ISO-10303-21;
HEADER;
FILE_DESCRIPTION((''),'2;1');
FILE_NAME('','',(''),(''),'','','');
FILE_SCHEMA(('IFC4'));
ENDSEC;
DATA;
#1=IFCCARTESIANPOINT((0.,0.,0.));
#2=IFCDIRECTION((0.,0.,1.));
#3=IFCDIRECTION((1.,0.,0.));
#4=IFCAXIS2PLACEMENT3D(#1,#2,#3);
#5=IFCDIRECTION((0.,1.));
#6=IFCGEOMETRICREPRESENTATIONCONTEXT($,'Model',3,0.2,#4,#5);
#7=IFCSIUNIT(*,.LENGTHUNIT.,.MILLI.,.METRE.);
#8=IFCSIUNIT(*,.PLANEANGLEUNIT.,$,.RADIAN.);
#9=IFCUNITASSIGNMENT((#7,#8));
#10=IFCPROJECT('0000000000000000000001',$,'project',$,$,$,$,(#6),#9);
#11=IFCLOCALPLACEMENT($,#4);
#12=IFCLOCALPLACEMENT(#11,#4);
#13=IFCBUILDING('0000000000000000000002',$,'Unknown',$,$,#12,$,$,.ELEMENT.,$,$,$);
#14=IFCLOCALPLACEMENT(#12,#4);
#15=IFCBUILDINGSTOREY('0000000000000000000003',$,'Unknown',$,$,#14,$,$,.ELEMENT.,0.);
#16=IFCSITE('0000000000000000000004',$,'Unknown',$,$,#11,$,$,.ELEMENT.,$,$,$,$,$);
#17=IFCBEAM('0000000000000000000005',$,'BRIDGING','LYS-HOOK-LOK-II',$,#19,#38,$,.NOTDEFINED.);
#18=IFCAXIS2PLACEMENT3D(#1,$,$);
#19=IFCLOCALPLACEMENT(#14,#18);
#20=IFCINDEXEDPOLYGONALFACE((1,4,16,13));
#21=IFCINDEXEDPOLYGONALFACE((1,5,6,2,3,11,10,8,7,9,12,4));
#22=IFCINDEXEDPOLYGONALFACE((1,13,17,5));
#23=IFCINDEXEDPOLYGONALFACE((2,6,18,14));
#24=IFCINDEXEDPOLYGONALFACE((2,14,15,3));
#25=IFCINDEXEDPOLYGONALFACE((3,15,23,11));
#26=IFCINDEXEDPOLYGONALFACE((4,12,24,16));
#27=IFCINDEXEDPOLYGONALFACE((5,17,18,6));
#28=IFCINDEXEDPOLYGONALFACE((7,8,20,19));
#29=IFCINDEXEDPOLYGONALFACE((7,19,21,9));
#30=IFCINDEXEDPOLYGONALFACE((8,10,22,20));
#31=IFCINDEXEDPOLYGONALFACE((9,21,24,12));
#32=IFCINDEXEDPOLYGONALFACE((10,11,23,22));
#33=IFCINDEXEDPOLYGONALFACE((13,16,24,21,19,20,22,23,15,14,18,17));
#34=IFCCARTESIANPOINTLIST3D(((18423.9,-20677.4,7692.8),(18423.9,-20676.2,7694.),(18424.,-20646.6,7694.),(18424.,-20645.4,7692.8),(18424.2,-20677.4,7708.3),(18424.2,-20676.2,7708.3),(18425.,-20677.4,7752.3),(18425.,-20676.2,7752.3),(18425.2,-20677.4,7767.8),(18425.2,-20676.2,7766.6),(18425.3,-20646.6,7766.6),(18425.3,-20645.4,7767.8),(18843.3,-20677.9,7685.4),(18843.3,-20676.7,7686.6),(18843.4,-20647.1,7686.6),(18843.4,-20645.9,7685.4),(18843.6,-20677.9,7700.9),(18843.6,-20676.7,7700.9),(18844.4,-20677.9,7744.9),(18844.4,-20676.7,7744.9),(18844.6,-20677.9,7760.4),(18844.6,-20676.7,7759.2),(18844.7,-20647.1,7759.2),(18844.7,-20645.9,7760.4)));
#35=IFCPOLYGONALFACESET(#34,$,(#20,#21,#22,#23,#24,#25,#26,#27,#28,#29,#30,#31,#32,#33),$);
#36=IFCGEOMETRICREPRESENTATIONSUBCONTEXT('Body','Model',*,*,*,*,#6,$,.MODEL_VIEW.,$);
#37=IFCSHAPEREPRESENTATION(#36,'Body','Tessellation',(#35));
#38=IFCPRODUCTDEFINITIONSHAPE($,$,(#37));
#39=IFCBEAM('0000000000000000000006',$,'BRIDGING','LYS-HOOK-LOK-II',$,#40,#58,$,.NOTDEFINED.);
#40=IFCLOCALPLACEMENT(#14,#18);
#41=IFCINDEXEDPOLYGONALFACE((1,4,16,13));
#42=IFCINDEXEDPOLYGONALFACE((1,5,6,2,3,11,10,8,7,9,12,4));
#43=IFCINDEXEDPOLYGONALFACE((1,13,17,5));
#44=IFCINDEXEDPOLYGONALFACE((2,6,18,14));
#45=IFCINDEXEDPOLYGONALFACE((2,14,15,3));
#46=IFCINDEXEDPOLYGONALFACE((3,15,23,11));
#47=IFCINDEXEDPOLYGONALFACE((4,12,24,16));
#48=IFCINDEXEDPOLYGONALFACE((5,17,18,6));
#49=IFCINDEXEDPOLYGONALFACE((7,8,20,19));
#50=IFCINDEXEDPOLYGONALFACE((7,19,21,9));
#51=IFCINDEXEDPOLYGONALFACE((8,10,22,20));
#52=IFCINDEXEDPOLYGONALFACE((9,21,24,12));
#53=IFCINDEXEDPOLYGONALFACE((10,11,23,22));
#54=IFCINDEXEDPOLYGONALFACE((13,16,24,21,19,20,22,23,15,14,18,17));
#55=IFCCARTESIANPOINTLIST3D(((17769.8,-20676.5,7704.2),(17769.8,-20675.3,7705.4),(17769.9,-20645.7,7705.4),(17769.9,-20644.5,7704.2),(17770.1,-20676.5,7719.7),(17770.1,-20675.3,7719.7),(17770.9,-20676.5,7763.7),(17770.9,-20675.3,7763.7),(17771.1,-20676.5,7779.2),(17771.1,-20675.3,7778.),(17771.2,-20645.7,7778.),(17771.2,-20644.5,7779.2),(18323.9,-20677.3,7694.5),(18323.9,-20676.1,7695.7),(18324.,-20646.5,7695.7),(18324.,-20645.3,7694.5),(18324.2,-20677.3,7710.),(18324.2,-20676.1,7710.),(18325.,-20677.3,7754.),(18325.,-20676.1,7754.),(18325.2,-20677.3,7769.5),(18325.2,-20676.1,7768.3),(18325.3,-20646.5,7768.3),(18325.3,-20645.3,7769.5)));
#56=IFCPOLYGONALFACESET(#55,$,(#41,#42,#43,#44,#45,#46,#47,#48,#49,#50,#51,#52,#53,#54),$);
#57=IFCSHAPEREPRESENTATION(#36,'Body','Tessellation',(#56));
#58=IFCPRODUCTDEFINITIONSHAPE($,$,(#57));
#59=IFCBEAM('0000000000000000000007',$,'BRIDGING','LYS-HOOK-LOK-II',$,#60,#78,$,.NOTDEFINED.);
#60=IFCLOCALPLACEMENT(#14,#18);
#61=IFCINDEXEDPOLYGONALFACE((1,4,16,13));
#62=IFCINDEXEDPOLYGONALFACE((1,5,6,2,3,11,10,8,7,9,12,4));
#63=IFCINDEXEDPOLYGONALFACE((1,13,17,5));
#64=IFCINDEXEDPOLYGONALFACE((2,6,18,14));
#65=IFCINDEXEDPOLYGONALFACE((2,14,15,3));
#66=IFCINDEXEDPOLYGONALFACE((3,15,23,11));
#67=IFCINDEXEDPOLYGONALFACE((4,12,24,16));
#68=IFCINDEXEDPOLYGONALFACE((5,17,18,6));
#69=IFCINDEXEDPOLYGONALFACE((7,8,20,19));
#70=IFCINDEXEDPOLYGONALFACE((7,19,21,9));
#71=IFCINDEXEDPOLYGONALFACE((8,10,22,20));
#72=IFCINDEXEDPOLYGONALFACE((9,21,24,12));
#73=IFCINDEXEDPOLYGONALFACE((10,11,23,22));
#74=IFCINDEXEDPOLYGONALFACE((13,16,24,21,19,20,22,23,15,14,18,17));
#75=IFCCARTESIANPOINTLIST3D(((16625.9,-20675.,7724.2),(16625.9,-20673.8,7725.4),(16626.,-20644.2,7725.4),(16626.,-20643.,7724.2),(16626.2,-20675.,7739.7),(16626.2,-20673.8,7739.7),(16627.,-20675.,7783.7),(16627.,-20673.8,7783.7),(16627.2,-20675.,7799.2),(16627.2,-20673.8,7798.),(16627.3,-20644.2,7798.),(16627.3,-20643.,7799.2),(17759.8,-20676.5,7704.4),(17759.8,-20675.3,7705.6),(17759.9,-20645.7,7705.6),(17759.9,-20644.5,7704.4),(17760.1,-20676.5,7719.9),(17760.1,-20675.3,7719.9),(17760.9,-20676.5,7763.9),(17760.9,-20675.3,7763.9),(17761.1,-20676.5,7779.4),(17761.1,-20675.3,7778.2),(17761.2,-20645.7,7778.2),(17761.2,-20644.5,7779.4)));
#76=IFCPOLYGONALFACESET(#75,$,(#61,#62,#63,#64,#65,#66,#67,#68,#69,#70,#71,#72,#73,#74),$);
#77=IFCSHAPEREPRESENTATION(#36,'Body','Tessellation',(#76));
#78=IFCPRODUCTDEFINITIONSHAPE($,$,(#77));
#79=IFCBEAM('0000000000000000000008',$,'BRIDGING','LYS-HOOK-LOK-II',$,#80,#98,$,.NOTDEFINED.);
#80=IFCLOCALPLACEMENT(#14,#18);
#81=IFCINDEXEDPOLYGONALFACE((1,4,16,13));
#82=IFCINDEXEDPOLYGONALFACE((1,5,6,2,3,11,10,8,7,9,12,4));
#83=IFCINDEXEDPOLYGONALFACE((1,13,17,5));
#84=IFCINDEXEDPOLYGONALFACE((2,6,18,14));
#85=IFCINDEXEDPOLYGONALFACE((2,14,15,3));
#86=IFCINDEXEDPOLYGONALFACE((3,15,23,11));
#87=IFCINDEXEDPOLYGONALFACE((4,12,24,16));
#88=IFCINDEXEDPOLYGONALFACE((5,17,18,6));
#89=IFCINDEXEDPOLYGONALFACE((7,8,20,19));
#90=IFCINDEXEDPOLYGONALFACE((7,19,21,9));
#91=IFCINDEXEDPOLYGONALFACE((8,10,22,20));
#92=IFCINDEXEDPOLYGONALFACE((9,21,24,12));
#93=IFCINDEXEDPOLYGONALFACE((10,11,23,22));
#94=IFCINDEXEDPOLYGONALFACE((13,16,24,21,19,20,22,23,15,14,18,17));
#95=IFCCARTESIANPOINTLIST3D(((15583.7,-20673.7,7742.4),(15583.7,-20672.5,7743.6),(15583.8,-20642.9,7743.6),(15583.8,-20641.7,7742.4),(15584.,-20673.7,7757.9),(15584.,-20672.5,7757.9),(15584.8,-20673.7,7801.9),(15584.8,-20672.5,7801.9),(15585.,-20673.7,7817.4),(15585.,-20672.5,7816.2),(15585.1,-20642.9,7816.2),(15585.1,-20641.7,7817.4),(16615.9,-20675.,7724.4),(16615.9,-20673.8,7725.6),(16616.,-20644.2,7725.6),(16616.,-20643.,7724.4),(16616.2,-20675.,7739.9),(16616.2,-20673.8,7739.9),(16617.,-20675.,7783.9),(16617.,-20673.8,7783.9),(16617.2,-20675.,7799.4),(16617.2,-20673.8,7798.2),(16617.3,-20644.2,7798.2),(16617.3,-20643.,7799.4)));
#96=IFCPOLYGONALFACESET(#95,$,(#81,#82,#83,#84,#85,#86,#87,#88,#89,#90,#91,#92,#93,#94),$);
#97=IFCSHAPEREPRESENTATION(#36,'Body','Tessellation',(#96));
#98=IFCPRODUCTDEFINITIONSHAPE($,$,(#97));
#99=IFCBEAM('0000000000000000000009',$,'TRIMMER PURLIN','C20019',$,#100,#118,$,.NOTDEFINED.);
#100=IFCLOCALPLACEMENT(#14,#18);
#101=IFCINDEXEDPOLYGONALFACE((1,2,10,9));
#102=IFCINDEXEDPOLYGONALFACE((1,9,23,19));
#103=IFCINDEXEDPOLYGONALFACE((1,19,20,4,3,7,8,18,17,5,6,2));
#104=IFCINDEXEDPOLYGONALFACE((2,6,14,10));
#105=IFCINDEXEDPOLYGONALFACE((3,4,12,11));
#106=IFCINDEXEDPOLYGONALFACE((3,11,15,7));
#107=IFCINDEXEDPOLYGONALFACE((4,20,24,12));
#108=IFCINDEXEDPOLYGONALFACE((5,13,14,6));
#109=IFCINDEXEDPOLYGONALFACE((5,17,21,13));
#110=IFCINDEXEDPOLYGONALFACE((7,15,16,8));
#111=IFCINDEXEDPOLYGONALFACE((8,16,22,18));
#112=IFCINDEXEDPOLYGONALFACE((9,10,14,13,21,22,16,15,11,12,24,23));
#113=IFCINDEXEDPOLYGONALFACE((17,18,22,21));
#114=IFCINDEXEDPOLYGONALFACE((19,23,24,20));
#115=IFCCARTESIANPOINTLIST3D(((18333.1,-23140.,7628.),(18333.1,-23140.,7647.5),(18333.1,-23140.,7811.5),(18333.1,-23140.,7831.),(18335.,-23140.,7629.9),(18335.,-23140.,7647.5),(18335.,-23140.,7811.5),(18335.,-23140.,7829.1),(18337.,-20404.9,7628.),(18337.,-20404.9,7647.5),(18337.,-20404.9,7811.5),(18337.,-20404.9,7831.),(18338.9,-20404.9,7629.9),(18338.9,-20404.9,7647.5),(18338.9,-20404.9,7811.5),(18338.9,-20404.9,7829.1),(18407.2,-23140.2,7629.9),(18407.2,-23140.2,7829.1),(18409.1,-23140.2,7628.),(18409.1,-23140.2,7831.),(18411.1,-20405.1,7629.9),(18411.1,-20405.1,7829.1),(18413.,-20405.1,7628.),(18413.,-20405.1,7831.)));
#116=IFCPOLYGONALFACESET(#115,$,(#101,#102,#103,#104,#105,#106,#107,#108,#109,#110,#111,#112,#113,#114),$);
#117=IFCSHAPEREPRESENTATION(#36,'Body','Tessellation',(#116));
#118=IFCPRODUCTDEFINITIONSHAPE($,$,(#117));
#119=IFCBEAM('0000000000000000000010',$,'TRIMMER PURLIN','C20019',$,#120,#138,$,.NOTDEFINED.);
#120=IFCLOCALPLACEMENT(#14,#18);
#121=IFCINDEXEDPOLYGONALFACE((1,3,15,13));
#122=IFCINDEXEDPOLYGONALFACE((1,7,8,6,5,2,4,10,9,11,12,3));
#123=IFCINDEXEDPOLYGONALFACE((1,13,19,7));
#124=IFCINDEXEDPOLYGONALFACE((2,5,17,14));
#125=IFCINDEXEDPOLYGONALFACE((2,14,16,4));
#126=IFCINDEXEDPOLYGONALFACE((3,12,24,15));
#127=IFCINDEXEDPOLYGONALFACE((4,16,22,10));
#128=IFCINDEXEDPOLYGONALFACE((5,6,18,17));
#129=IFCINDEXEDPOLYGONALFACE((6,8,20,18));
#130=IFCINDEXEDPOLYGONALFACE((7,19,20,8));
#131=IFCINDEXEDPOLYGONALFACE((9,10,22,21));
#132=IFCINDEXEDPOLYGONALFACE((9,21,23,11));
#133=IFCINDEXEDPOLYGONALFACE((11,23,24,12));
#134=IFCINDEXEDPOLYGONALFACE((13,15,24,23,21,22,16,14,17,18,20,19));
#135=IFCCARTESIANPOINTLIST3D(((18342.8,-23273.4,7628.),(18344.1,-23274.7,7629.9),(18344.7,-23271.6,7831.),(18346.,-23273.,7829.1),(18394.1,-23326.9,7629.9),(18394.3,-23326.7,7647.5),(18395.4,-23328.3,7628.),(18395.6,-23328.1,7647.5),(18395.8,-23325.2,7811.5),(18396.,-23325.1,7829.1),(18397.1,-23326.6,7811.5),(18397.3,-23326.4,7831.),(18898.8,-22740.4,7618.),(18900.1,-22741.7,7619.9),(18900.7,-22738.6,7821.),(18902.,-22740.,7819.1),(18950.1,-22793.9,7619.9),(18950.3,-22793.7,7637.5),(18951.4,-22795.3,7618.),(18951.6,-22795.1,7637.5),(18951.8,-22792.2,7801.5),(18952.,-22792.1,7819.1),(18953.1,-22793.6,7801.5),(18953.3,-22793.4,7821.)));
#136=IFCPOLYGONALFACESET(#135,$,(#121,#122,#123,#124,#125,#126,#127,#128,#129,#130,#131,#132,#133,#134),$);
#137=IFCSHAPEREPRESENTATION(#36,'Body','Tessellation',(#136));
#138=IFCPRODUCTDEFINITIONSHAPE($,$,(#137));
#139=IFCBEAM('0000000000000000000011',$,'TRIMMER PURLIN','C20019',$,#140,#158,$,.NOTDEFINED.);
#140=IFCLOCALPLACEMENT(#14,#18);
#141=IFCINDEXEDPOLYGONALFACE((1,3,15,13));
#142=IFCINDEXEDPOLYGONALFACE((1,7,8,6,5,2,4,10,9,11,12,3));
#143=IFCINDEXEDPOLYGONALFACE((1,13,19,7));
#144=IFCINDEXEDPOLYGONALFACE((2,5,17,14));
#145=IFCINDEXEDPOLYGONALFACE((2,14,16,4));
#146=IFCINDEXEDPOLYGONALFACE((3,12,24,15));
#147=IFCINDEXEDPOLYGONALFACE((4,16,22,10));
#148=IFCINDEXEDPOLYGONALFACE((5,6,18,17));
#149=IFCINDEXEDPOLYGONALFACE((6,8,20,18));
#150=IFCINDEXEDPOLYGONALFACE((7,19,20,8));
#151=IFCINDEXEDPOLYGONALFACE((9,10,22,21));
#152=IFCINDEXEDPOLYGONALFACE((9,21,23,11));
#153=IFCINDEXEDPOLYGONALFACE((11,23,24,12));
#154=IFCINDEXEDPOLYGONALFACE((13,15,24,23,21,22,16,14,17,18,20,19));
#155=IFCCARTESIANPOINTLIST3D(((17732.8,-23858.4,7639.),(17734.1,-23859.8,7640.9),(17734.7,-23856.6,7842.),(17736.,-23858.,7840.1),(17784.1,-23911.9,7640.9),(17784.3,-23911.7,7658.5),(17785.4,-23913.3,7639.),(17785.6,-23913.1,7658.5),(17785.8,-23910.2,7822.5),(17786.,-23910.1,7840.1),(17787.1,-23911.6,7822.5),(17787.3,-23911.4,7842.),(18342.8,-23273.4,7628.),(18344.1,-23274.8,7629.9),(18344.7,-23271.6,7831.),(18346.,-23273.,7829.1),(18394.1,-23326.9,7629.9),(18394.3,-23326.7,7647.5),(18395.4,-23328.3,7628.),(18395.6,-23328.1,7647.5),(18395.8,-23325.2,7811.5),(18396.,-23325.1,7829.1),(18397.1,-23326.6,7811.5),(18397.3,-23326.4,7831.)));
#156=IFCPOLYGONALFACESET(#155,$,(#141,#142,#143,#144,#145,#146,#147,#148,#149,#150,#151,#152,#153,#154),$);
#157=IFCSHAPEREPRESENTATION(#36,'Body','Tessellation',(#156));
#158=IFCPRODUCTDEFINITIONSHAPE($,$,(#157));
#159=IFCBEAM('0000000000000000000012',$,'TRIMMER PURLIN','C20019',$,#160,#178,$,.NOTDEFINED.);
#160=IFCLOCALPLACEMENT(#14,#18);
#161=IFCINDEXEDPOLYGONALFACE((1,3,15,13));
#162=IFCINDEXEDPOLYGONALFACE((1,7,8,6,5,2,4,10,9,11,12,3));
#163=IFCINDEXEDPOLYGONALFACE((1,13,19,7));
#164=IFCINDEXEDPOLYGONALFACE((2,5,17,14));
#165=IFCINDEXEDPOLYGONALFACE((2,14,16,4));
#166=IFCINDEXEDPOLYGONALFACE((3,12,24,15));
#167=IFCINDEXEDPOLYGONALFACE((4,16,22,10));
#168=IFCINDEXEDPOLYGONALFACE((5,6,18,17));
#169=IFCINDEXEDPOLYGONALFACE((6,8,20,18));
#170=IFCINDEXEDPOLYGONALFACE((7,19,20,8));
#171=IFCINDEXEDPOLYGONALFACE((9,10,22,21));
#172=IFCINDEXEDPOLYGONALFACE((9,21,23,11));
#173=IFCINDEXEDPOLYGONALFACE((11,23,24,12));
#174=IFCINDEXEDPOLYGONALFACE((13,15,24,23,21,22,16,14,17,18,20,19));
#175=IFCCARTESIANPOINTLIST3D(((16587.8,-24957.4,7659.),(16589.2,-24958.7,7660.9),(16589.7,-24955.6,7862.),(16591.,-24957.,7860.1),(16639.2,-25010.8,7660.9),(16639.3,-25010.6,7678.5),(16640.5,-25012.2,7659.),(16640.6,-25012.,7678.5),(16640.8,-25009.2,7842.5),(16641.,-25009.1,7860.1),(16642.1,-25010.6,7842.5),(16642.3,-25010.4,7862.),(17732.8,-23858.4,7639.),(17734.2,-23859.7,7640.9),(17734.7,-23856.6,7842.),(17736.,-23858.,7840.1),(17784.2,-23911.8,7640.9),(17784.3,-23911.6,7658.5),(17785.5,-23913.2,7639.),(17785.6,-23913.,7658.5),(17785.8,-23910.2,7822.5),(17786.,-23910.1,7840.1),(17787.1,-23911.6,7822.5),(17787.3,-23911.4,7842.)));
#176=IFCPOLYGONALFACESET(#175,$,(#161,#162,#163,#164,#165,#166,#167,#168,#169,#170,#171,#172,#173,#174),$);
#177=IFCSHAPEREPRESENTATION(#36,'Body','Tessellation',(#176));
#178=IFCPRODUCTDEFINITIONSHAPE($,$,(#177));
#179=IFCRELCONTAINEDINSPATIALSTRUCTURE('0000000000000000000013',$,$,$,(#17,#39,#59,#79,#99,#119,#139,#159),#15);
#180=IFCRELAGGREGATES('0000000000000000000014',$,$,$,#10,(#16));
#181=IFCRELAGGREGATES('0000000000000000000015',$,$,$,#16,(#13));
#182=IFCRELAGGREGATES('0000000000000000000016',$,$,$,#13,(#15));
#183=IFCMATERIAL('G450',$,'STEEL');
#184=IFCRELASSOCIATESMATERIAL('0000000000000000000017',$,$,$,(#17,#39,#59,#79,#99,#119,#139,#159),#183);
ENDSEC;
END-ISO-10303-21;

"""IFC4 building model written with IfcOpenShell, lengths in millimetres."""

from ifc_helpers import new_model, si_unit, direction, frame, origin_with_axes, place, context, subcontext, project, spatial, line, indexed_curve, outline, extrude, material, element, save


model = new_model("IFC4")

# Units and contexts
model_context = context("Model", 3, precision=0.2, world=origin_with_axes(), true_north=direction((0.0, 1.0)))
body_context = subcontext(model_context, "Body", "Model", "MODEL_VIEW")
ifc_project = project(units=[si_unit("LENGTHUNIT", "METRE", prefix="MILLI"), si_unit("PLANEANGLEUNIT", "RADIAN")], contexts=[model_context])

# Site, building, storey
site_placement = place(None, origin_with_axes())
site = spatial("IfcSite", under=ifc_project, at=site_placement, Name="Unknown", CompositionType="ELEMENT")
building_placement = place(site_placement, origin_with_axes())
building = spatial("IfcBuilding", under=site, at=building_placement, Name="Unknown", CompositionType="ELEMENT")
storey_placement = place(building_placement, origin_with_axes())
storey = spatial("IfcBuildingStorey", under=building, at=storey_placement, Name="Unknown", CompositionType="ELEMENT", Elevation=0.0)

# Beams
ifc_material_1 = material(Name="G450", Category="STEEL")
beam_1_placement = place(storey_placement, frame((18424.6, -20661.4, 7730.3), z_axis=(-0.001192, -0.999999, 0.0), x_axis=(0.999844, -0.001192, -0.017641)))
element("IfcBeam", 1, at=beam_1_placement, inside=storey, material=ifc_material_1, Name="BRIDGING", Description="LYS-HOOK-LOK-II", PredefinedType="NOTDEFINED", context=body_context, shape_type="SolidModel", body=[
    extrude(outline(indexed_curve([(16.0, -37.5), (16.0, -22.0), (14.8, -22.0), (14.8, -36.3), (-14.8, -36.3), (-14.8, 36.3), (14.8, 36.3), (14.8, 22.0), (16.0, 22.0), (16.0, 37.5), (-16.0, 37.5), (-16.0, -37.5)], segments=[line(1, 2, 3, 4, 5, 6, 7, 8, 9, 10, 11, 12, 1)])), frame((0.0, 0.0, 0.0), z_axis=(-1.0, 0.0, 0.0), x_axis=(0.0, 0.0, 1.0)), (0.0, 0.0, -1.0), 419.5),
])
beam_2_placement = place(storey_placement, frame((17770.5, -20660.5, 7741.7), z_axis=(-0.001444, -0.999999, 0.0), x_axis=(0.999846, -0.001444, -0.017503)))
element("IfcBeam", 2, at=beam_2_placement, inside=storey, material=ifc_material_1, Name="BRIDGING", Description="LYS-HOOK-LOK-II", PredefinedType="NOTDEFINED", context=body_context, shape_type="SolidModel", body=[
    extrude(outline(indexed_curve([(16.0, -37.5), (16.0, -22.0), (14.8, -22.0), (14.8, -36.3), (-14.8, -36.3), (-14.8, 36.3), (14.8, 36.3), (14.8, 22.0), (16.0, 22.0), (16.0, 37.5), (-16.0, 37.5), (-16.0, -37.5)], segments=[line(1, 2, 3, 4, 5, 6, 7, 8, 9, 10, 11, 12, 1)])), frame((0.0, 0.0, 0.0), z_axis=(-1.0, 0.0, 0.0), x_axis=(0.0, 0.0, 1.0)), (0.0, 0.0, -1.0), 554.2),
])
beam_3_placement = place(storey_placement, frame((16626.6, -20659.0, 7761.7), z_axis=(-0.001323, -0.999999, 0.0), x_axis=(0.999847, -0.001323, -0.017459)))
element("IfcBeam", 3, at=beam_3_placement, inside=storey, material=ifc_material_1, Name="BRIDGING", Description="LYS-HOOK-LOK-II", PredefinedType="NOTDEFINED", context=body_context, shape_type="SolidModel", body=[
    extrude(outline(indexed_curve([(16.0, -37.5), (16.0, -22.0), (14.8, -22.0), (14.8, -36.3), (-14.8, -36.3), (-14.8, 36.3), (14.8, 36.3), (14.8, 22.0), (16.0, 22.0), (16.0, 37.5), (-16.0, 37.5), (-16.0, -37.5)], segments=[line(1, 2, 3, 4, 5, 6, 7, 8, 9, 10, 11, 12, 1)])), frame((0.0, 0.0, 0.0), z_axis=(-1.0, 0.0, 0.0), x_axis=(0.0, 0.0, 1.0)), (0.0, 0.0, -1.0), 1134.1),
])
beam_4_placement = place(storey_placement, frame((15584.4, -20657.7, 7779.9), z_axis=(-0.001259, -0.999999, 0.0), x_axis=(0.999847, -0.001259, -0.017436)))
element("IfcBeam", 4, at=beam_4_placement, inside=storey, material=ifc_material_1, Name="BRIDGING", Description="LYS-HOOK-LOK-II", PredefinedType="NOTDEFINED", context=body_context, shape_type="SolidModel", body=[
    extrude(outline(indexed_curve([(16.0, -37.5), (16.0, -22.0), (14.8, -22.0), (14.8, -36.3), (-14.8, -36.3), (-14.8, 36.3), (14.8, 36.3), (14.8, 22.0), (16.0, 22.0), (16.0, 37.5), (-16.0, 37.5), (-16.0, -37.5)], segments=[line(1, 2, 3, 4, 5, 6, 7, 8, 9, 10, 11, 12, 1)])), frame((0.0, 0.0, 0.0), z_axis=(-1.0, 0.0, 0.0), x_axis=(0.0, 0.0, 1.0)), (0.0, 0.0, -1.0), 1032.4),
])
beam_5_placement = place(storey_placement, frame((18375.0, -20405.0, 7729.5), z_axis=(-0.999999, 0.001426, 0.0), x_axis=(-0.001426, -0.999999, 0.0)))
element("IfcBeam", 5, at=beam_5_placement, inside=storey, material=ifc_material_1, Name="TRIMMER PURLIN", Description="C20019", PredefinedType="NOTDEFINED", context=body_context, shape_type="SolidModel", body=[
    extrude(outline(indexed_curve([(38.0, -101.5), (38.0, -82.0), (36.1, -82.0), (36.1, -99.6), (-36.1, -99.6), (-36.1, 99.6), (36.1, 99.6), (36.1, 82.0), (38.0, 82.0), (38.0, 101.5), (-38.0, 101.5), (-38.0, -101.5)], segments=[line(1, 2, 3, 4, 5, 6, 7, 8, 9, 10, 11, 12, 1)])), frame((0.0, 0.0, 0.0), z_axis=(-1.0, 0.0, 0.0), x_axis=(0.0, 0.0, 1.0)), (0.0, 0.0, -1.0), 2735.1),
])
beam_6_placement = place(storey_placement, frame((18370.0, -23299.9, 7729.5), z_axis=(0.692018, -0.72188, 0.0), x_axis=(0.721819, 0.69196, -0.012982)))
element("IfcBeam", 6, at=beam_6_placement, inside=storey, material=ifc_material_1, Name="TRIMMER PURLIN", Description="C20019", PredefinedType="NOTDEFINED", context=body_context, shape_type="SolidModel", body=[
    extrude(outline(indexed_curve([(38.0, -101.5), (38.0, -82.0), (36.1, -82.0), (36.1, -99.6), (-36.1, -99.6), (-36.1, 99.6), (36.1, 99.6), (36.1, 82.0), (38.0, 82.0), (38.0, 101.5), (-38.0, 101.5), (-38.0, -101.5)], segments=[line(1, 2, 3, 4, 5, 6, 7, 8, 9, 10, 11, 12, 1)])), frame((0.0, 0.0, 0.0), z_axis=(-1.0, 0.0, 0.0), x_axis=(0.0, 0.0, 1.0)), (0.0, 0.0, -1.0), 770.3),
])
beam_7_placement = place(storey_placement, frame((17760.0, -23884.9, 7740.5), z_axis=(0.692162, -0.721742, 0.0), x_axis=(0.721681, 0.692104, -0.013014)))
element("IfcBeam", 7, at=beam_7_placement, inside=storey, material=ifc_material_1, Name="TRIMMER PURLIN", Description="C20019", PredefinedType="NOTDEFINED", context=body_context, shape_type="SolidModel", body=[
    extrude(outline(indexed_curve([(38.0, -101.5), (38.0, -82.0), (36.1, -82.0), (36.1, -99.6), (-36.1, -99.6), (-36.1, 99.6), (36.1, 99.6), (36.1, 82.0), (38.0, 82.0), (38.0, 101.5), (-38.0, 101.5), (-38.0, -101.5)], segments=[line(1, 2, 3, 4, 5, 6, 7, 8, 9, 10, 11, 12, 1)])), frame((0.0, 0.0, 0.0), z_axis=(-1.0, 0.0, 0.0), x_axis=(0.0, 0.0, 1.0)), (0.0, 0.0, -1.0), 845.2),
])
beam_8_placement = place(storey_placement, frame((16615.1, -24983.9, 7760.5), z_axis=(0.692466, -0.72145, 0.0), x_axis=(0.721393, 0.692411, -0.012601)))
element("IfcBeam", 8, at=beam_8_placement, inside=storey, material=ifc_material_1, Name="TRIMMER PURLIN", Description="C20019", PredefinedType="NOTDEFINED", context=body_context, shape_type="SolidModel", body=[
    extrude(outline(indexed_curve([(38.0, -101.5), (38.0, -82.0), (36.1, -82.0), (36.1, -99.6), (-36.1, -99.6), (-36.1, 99.6), (36.1, 99.6), (36.1, 82.0), (38.0, 82.0), (38.0, 101.5), (-38.0, 101.5), (-38.0, -101.5)], segments=[line(1, 2, 3, 4, 5, 6, 7, 8, 9, 10, 11, 12, 1)])), frame((0.0, 0.0, 0.0), z_axis=(-1.0, 0.0, 0.0), x_axis=(0.0, 0.0, 1.0)), (0.0, 0.0, -1.0), 1587.2),
])

save(model, "model.ifc")
